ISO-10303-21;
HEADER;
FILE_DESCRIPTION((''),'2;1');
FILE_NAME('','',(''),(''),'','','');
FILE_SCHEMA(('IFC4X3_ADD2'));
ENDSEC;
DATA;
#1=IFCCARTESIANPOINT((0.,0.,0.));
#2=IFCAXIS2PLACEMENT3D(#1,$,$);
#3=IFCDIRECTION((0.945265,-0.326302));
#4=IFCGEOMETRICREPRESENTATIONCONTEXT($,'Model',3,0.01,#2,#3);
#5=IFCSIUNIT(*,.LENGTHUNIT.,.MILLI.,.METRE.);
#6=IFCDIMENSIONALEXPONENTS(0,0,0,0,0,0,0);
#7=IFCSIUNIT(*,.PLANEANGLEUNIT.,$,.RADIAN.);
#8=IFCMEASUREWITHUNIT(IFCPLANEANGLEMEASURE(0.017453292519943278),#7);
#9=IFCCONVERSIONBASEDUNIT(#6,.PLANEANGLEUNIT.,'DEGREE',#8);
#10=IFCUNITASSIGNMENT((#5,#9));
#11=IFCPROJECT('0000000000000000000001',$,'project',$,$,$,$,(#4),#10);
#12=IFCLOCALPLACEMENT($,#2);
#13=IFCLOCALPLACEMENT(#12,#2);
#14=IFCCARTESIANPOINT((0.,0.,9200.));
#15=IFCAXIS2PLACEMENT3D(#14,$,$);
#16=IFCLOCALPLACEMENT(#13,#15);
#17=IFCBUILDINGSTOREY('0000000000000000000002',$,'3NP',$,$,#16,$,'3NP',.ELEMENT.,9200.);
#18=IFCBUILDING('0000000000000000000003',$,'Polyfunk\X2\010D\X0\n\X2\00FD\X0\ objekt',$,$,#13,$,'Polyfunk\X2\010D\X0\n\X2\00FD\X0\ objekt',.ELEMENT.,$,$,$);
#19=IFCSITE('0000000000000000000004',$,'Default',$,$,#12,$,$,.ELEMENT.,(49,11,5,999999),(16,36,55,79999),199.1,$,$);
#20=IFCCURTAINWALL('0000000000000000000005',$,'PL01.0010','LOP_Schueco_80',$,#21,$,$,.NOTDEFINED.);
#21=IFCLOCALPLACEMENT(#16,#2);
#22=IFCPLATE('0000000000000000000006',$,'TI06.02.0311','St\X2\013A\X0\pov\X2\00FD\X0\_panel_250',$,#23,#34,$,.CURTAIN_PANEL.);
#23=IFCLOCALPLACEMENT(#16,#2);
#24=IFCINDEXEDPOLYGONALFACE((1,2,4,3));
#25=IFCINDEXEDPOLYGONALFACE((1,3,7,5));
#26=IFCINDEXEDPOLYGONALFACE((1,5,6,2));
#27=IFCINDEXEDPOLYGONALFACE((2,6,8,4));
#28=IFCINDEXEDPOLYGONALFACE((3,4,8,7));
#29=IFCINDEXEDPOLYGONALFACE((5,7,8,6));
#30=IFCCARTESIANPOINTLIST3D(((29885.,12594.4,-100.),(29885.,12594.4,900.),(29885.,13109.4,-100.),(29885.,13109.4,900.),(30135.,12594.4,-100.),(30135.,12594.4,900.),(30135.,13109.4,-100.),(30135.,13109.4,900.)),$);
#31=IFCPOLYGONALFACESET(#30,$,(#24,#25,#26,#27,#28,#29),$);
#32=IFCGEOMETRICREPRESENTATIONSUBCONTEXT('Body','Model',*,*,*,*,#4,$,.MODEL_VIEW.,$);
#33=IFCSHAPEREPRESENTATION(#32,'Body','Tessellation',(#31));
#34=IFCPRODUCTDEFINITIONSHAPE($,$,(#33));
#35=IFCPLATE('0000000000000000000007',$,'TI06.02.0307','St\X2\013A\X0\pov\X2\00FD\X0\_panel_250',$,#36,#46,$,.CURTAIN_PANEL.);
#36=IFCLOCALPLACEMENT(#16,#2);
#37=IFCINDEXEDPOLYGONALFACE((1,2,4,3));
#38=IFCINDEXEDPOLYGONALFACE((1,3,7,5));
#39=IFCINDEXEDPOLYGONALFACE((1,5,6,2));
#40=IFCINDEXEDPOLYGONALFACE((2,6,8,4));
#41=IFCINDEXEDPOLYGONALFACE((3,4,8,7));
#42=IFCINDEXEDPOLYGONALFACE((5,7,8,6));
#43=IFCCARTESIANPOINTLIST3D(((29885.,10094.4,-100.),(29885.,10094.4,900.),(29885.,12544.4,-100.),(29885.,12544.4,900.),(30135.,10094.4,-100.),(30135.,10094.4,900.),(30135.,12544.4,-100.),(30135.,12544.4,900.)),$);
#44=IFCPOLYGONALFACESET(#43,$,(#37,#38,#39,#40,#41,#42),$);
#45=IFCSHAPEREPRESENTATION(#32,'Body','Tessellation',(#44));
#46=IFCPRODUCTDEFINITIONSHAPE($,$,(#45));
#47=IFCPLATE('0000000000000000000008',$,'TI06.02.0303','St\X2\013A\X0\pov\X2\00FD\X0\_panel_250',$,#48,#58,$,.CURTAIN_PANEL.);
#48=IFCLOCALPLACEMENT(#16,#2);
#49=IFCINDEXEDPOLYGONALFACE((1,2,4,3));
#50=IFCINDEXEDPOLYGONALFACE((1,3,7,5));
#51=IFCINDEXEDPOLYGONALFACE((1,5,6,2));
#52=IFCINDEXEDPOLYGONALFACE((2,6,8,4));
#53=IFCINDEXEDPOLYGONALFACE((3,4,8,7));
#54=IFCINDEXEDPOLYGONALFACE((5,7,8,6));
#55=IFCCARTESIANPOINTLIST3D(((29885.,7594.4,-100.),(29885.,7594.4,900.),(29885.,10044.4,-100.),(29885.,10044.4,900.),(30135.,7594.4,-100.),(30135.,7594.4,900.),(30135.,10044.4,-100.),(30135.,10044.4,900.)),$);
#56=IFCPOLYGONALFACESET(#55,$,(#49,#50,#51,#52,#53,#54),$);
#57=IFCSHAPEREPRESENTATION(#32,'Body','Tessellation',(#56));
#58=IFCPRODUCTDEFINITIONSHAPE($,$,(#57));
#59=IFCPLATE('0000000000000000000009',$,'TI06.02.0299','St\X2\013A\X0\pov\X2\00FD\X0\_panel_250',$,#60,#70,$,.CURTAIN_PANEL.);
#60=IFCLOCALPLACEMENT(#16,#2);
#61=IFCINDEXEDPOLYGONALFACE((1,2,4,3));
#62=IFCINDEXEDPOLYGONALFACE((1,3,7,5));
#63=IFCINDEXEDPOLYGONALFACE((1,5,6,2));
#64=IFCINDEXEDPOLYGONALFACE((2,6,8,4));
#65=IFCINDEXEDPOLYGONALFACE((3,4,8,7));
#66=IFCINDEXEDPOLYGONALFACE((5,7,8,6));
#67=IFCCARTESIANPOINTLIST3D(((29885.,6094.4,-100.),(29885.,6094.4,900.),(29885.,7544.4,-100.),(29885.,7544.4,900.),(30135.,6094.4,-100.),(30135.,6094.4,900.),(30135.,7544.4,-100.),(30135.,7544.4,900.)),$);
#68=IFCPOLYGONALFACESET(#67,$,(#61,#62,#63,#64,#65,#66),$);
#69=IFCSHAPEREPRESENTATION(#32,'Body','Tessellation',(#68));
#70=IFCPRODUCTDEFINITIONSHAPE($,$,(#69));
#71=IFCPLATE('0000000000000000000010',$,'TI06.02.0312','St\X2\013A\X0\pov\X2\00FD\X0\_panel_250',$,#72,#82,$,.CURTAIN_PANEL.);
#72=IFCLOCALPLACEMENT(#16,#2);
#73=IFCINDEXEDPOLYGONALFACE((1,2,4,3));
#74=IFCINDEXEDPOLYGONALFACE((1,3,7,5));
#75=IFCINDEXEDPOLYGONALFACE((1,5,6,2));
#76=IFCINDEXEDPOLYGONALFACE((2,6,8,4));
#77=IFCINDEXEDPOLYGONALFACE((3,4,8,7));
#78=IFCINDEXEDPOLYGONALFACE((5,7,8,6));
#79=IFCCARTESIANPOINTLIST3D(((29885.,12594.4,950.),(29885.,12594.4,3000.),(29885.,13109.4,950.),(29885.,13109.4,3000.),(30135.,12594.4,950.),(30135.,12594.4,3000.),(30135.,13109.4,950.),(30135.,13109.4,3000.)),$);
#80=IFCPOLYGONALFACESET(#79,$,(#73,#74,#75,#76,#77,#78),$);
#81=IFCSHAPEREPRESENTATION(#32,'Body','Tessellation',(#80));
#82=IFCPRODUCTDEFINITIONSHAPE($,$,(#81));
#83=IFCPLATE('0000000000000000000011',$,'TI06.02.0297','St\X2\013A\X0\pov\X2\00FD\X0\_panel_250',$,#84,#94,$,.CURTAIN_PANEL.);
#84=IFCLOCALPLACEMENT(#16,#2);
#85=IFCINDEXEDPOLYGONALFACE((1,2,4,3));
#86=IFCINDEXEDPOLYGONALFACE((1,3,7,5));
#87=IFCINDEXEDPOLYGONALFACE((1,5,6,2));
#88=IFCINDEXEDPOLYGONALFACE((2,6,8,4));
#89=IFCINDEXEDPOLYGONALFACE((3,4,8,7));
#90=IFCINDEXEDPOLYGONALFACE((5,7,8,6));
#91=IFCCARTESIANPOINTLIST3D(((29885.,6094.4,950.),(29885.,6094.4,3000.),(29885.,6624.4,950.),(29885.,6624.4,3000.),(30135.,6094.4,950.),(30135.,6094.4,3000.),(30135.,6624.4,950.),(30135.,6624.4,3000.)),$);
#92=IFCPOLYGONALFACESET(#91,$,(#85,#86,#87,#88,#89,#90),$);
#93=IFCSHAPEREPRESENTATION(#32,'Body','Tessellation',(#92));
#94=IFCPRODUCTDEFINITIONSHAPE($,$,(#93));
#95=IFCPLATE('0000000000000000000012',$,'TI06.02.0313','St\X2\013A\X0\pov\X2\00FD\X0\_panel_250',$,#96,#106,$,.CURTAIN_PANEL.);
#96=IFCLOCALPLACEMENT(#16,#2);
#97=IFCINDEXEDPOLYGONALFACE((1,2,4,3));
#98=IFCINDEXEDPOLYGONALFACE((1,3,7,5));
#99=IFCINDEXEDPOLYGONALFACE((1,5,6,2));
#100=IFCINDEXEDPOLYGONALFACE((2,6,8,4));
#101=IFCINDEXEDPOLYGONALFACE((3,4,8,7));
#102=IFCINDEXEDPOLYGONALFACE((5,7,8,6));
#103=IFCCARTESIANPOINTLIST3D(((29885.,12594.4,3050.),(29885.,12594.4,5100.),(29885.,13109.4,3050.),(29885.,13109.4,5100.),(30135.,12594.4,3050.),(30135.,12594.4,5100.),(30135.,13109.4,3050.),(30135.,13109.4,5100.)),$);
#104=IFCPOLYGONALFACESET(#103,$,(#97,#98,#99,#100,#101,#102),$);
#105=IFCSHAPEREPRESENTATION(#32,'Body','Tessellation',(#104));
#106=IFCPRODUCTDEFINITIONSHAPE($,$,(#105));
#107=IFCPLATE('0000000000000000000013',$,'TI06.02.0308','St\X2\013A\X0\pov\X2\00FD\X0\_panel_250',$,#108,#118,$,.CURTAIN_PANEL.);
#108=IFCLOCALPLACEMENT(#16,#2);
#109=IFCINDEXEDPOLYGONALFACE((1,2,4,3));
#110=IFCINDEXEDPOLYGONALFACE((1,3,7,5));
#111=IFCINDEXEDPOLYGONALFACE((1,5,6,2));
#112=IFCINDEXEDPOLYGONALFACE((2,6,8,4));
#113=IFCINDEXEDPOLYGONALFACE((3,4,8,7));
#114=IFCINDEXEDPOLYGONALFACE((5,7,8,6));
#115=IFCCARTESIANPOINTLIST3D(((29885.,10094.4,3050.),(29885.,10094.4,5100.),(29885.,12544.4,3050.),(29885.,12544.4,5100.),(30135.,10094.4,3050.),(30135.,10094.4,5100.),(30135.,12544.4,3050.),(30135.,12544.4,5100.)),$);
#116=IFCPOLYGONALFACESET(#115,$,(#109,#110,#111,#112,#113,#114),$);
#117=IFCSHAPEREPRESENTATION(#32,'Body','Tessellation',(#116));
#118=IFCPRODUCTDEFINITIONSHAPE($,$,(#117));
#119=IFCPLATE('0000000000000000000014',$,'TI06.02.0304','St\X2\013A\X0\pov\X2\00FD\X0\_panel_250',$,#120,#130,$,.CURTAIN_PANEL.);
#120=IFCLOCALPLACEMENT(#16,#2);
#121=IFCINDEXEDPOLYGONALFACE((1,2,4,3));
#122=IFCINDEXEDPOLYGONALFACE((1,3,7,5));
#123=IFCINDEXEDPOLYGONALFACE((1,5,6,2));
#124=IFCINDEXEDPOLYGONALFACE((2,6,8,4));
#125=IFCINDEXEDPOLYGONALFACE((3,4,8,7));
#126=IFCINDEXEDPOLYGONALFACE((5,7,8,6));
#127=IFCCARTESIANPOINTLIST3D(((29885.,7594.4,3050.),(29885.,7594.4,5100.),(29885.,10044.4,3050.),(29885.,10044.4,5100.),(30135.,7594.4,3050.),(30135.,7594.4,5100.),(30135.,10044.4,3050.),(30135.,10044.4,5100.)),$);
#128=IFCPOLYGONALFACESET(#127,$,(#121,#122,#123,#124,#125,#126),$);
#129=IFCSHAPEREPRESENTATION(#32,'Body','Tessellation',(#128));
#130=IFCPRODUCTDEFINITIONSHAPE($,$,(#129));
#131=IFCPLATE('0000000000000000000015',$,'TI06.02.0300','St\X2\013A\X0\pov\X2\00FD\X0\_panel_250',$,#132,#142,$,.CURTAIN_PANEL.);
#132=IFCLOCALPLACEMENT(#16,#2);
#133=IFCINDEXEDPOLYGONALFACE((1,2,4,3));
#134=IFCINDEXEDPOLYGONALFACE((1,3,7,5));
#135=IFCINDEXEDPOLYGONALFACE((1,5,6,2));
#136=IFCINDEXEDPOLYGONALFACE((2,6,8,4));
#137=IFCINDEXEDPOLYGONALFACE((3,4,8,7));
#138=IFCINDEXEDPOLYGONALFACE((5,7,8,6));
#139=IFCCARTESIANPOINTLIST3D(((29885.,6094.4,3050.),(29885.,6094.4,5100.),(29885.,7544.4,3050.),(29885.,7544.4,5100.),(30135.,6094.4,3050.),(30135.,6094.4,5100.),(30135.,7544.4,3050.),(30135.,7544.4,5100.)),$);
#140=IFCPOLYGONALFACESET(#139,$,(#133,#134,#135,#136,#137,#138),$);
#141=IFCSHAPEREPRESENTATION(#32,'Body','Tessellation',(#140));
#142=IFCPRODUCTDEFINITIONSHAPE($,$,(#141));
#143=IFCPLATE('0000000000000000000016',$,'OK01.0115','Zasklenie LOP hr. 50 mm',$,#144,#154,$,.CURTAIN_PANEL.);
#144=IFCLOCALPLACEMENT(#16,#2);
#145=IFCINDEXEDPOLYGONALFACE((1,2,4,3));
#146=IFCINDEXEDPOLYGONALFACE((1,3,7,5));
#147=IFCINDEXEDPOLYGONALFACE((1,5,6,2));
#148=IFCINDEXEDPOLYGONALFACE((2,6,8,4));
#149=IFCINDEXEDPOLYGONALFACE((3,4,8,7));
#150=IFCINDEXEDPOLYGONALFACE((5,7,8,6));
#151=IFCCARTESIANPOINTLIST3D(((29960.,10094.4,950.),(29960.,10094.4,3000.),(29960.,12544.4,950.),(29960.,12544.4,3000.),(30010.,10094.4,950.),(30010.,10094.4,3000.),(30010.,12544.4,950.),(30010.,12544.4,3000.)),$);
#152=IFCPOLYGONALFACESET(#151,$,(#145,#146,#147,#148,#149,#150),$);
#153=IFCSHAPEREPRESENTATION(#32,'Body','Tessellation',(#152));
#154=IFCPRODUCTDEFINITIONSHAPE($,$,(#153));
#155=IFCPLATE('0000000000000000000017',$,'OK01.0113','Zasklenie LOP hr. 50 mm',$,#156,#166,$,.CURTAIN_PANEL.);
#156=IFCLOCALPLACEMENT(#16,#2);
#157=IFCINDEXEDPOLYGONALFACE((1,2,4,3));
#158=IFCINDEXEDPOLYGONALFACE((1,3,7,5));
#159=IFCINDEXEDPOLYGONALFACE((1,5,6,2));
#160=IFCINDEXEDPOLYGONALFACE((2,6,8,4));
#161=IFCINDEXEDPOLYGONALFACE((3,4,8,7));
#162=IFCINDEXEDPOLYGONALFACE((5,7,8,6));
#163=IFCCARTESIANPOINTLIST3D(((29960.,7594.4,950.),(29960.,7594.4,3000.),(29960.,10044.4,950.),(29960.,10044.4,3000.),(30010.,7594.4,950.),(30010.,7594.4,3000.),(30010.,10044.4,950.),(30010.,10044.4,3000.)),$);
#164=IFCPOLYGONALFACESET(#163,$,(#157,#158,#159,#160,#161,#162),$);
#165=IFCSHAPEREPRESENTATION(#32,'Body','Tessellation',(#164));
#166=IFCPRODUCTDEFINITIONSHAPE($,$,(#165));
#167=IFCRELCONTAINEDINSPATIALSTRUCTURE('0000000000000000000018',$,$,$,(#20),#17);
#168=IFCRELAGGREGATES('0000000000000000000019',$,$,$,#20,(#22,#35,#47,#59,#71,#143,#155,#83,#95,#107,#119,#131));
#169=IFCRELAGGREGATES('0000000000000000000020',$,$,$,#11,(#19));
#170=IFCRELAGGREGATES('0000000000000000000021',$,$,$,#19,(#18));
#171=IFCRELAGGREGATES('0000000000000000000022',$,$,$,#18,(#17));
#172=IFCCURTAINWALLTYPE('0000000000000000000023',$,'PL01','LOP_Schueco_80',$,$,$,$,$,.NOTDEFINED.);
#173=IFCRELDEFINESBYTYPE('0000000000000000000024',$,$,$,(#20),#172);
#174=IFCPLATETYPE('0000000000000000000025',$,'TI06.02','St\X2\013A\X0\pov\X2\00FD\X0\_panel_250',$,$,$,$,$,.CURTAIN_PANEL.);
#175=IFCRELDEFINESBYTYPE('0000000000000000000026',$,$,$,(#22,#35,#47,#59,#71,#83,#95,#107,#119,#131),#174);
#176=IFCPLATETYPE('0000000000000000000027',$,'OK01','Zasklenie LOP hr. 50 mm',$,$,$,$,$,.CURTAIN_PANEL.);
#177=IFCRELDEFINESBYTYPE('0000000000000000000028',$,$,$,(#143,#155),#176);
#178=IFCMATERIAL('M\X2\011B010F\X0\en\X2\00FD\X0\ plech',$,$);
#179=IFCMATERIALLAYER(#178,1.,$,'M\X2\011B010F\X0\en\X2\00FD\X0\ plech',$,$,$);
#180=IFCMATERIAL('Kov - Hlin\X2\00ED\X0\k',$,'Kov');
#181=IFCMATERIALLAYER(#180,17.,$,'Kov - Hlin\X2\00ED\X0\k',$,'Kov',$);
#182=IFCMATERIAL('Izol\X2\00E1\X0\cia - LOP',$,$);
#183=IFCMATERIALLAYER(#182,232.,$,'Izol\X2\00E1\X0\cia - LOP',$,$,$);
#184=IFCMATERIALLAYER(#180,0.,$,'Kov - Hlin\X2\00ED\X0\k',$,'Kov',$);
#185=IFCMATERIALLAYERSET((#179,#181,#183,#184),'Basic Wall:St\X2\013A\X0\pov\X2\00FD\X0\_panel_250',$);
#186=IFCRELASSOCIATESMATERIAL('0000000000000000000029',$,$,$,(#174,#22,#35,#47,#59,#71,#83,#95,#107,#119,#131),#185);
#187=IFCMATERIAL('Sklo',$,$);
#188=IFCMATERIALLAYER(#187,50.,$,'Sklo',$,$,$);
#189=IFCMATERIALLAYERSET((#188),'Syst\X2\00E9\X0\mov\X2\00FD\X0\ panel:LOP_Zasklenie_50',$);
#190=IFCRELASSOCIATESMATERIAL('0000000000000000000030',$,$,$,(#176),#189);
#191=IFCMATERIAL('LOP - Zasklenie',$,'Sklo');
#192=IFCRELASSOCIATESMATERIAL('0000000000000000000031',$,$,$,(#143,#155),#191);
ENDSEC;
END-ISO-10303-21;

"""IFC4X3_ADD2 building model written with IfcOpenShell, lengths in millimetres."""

from ifc_helpers import new_model, entity, si_unit, converted_unit, direction, frame, frame_2d, origin, origin_2d_with_axis, place, context, subcontext, project, spatial, rectangle, extrude, source, transform, mapped, material, layer, layer_set, layer_usage, type_object, element, aggregate, save


model = new_model("IFC4X3_ADD2")

# Units and contexts
model_context = context("Model", 3, precision=0.01, world=origin(), true_north=direction((0.945265, -0.326302)))
body_context = subcontext(model_context, "Body", "Model", "MODEL_VIEW")
ifc_project = project(units=[si_unit("LENGTHUNIT", "METRE", prefix="MILLI"), converted_unit("PLANEANGLEUNIT", "DEGREE", entity("IfcPlaneAngleMeasure", 0.017453292519943278), si_unit("PLANEANGLEUNIT", "RADIAN"), dimensions=[0, 0, 0, 0, 0, 0, 0])], contexts=[model_context])

# Site, building, storey
site_placement = place(None, origin())
site = spatial("IfcSite", under=ifc_project, at=site_placement, Name="Default", CompositionType="ELEMENT", RefLatitude=(49, 11, 5, 999999), RefLongitude=(16, 36, 55, 79999), RefElevation=199.1)
building_placement = place(site_placement, origin())
building = spatial("IfcBuilding", under=site, at=building_placement, Name="Polyfunkčný objekt", LongName="Polyfunkčný objekt", CompositionType="ELEMENT")
storey_placement = place(building_placement, frame((0.0, 0.0, 9200.0)))
storey = spatial("IfcBuildingStorey", under=building, at=storey_placement, Name="3NP", LongName="3NP", CompositionType="ELEMENT", Elevation=9200.0)

# Shared definitions
curtain_wall_type = type_object("IfcCurtainWallType", Name="PL01", Description="LOP_Schueco_80", PredefinedType="NOTDEFINED")

# Curtain wall, plates
curtain_wall_1_placement = place(storey_placement, frame((0.0, 0.0, -9200.0)))
curtain_wall_1 = element("IfcCurtainWall", 1, at=curtain_wall_1_placement, inside=storey, type_object=curtain_wall_type, Name="PL01.0010", Description="LOP_Schueco_80", PredefinedType="NOTDEFINED")
ifc_material_1 = material(Name="Měďený plech")
ifc_layer_1 = layer(ifc_material_1, 1.0, Name="Měďený plech")
ifc_material_2 = material(Name="Kov - Hliník", Category="Kov")
ifc_layer_2 = layer(ifc_material_2, 17.0, Name="Kov - Hliník", Category="Kov")
ifc_material_3 = material(Name="Izolácia - LOP")
ifc_layer_3 = layer(ifc_material_3, 232.0, Name="Izolácia - LOP")
ifc_layer_4 = layer(ifc_material_2, 0.0, Name="Kov - Hliník", Category="Kov")
ifc_layer_set_1 = layer_set([ifc_layer_1, ifc_layer_2, ifc_layer_3, ifc_layer_4], Name="Basic Wall:Stĺpový_panel_250")
ifc_layer_usage_1 = layer_usage(ifc_layer_set_1, "AXIS2", "POSITIVE", -125.0)
plate_type_1 = type_object("IfcPlateType", Name="TI06.02", Description="Stĺpový_panel_250", PredefinedType="CURTAIN_PANEL", material=ifc_layer_set_1)
plate_1_placement = place(storey_placement, frame((30010.0, 13109.4, -100.0), z_axis=(0.0, 0.0, 1.0), x_axis=(0.0, -1.0, 0.0)))
plate_1 = element("IfcPlate", 2, at=plate_1_placement, type_object=plate_type_1, material=ifc_layer_usage_1, Name="TI06.02.0311", Description="Stĺpový_panel_250", PredefinedType="CURTAIN_PANEL", context=body_context, shape_type="SweptSolid", body=[
    extrude(rectangle(XDim=250.0, YDim=515.0, at=frame_2d((0.0, 0.0), x_axis=(1.0, 0.0))), frame((257.5, 0.0, 0.0), z_axis=(0.0, 0.0, 1.0), x_axis=(0.0, 1.0, 0.0)), (0.0, 0.0, 1.0), 1000.0),
])
ifc_layer_usage_2 = layer_usage(ifc_layer_set_1, "AXIS2", "POSITIVE", -125.0)
plate_2_placement = place(storey_placement, frame((30010.0, 12544.4, -100.0), z_axis=(0.0, 0.0, 1.0), x_axis=(0.0, -1.0, 0.0)))
plate_2 = element("IfcPlate", 3, at=plate_2_placement, type_object=plate_type_1, material=ifc_layer_usage_2, Name="TI06.02.0307", Description="Stĺpový_panel_250", PredefinedType="CURTAIN_PANEL", context=body_context, shape_type="SweptSolid", body=[
    extrude(rectangle(XDim=250.0, YDim=2450.0, at=frame_2d((0.0, 0.0), x_axis=(1.0, 0.0))), frame((1225.0, 0.0, 0.0), z_axis=(0.0, 0.0, 1.0), x_axis=(0.0, 1.0, 0.0)), (0.0, 0.0, 1.0), 1000.0),
])
ifc_layer_usage_3 = layer_usage(ifc_layer_set_1, "AXIS2", "POSITIVE", -125.0)
plate_3_placement = place(storey_placement, frame((30010.0, 10044.4, -100.0), z_axis=(0.0, 0.0, 1.0), x_axis=(0.0, -1.0, 0.0)))
plate_3 = element("IfcPlate", 4, at=plate_3_placement, type_object=plate_type_1, material=ifc_layer_usage_3, Name="TI06.02.0303", Description="Stĺpový_panel_250", PredefinedType="CURTAIN_PANEL", context=body_context, shape_type="SweptSolid", body=[
    extrude(rectangle(XDim=250.0, YDim=2450.0, at=origin_2d_with_axis()), frame((1225.0, 0.0, 0.0), z_axis=(0.0, 0.0, 1.0), x_axis=(0.0, 1.0, 0.0)), (0.0, 0.0, 1.0), 1000.0),
])
ifc_layer_usage_4 = layer_usage(ifc_layer_set_1, "AXIS2", "POSITIVE", -125.0)
plate_4_placement = place(storey_placement, frame((30010.0, 7544.4, -100.0), z_axis=(0.0, 0.0, 1.0), x_axis=(0.0, -1.0, 0.0)))
plate_4 = element("IfcPlate", 5, at=plate_4_placement, type_object=plate_type_1, material=ifc_layer_usage_4, Name="TI06.02.0299", Description="Stĺpový_panel_250", PredefinedType="CURTAIN_PANEL", context=body_context, shape_type="SweptSolid", body=[
    extrude(rectangle(XDim=250.0, YDim=1450.0, at=frame_2d((0.0, 0.0), x_axis=(1.0, 0.0))), frame((725.0, 0.0, 0.0), z_axis=(0.0, 0.0, 1.0), x_axis=(0.0, 1.0, 0.0)), (0.0, 0.0, 1.0), 1000.0),
])
ifc_layer_usage_5 = layer_usage(ifc_layer_set_1, "AXIS2", "POSITIVE", -125.0)
plate_5_placement = place(storey_placement, frame((30010.0, 13109.4, 950.0), z_axis=(0.0, 0.0, 1.0), x_axis=(0.0, -1.0, 0.0)))
plate_5 = element("IfcPlate", 6, at=plate_5_placement, type_object=plate_type_1, material=ifc_layer_usage_5, Name="TI06.02.0312", Description="Stĺpový_panel_250", PredefinedType="CURTAIN_PANEL", context=body_context, shape_type="SweptSolid", body=[
    extrude(rectangle(XDim=250.0, YDim=515.0, at=frame_2d((0.0, 0.0), x_axis=(1.0, 0.0))), frame((257.5, 0.0, 0.0), z_axis=(0.0, 0.0, 1.0), x_axis=(0.0, 1.0, 0.0)), (0.0, 0.0, 1.0), 2050.0),
])
ifc_layer_usage_6 = layer_usage(ifc_layer_set_1, "AXIS2", "POSITIVE", -125.0)
plate_6_placement = place(storey_placement, frame((30010.0, 6624.4, 950.0), z_axis=(0.0, 0.0, 1.0), x_axis=(0.0, -1.0, 0.0)))
plate_6 = element("IfcPlate", 7, at=plate_6_placement, type_object=plate_type_1, material=ifc_layer_usage_6, Name="TI06.02.0297", Description="Stĺpový_panel_250", PredefinedType="CURTAIN_PANEL", context=body_context, shape_type="SweptSolid", body=[
    extrude(rectangle(XDim=250.0, YDim=530.0, at=frame_2d((0.0, 0.0), x_axis=(1.0, 0.0))), frame((265.0, 0.0, 0.0), z_axis=(0.0, 0.0, 1.0), x_axis=(0.0, 1.0, 0.0)), (0.0, 0.0, 1.0), 2050.0),
])
ifc_layer_usage_7 = layer_usage(ifc_layer_set_1, "AXIS2", "POSITIVE", -125.0)
plate_7_placement = place(storey_placement, frame((30010.0, 13109.4, 3050.0), z_axis=(0.0, 0.0, 1.0), x_axis=(0.0, -1.0, 0.0)))
plate_7 = element("IfcPlate", 8, at=plate_7_placement, type_object=plate_type_1, material=ifc_layer_usage_7, Name="TI06.02.0313", Description="Stĺpový_panel_250", PredefinedType="CURTAIN_PANEL", context=body_context, shape_type="SweptSolid", body=[
    extrude(rectangle(XDim=250.0, YDim=515.0, at=frame_2d((0.0, 0.0), x_axis=(1.0, 0.0))), frame((257.5, 0.0, 0.0), z_axis=(0.0, 0.0, 1.0), x_axis=(0.0, 1.0, 0.0)), (0.0, 0.0, 1.0), 2050.0),
])
ifc_layer_usage_8 = layer_usage(ifc_layer_set_1, "AXIS2", "POSITIVE", -125.0)
plate_8_placement = place(storey_placement, frame((30010.0, 12544.4, 3050.0), z_axis=(0.0, 0.0, 1.0), x_axis=(0.0, -1.0, 0.0)))
plate_8 = element("IfcPlate", 9, at=plate_8_placement, type_object=plate_type_1, material=ifc_layer_usage_8, Name="TI06.02.0308", Description="Stĺpový_panel_250", PredefinedType="CURTAIN_PANEL", context=body_context, shape_type="SweptSolid", body=[
    extrude(rectangle(XDim=250.0, YDim=2450.0, at=frame_2d((0.0, 0.0), x_axis=(1.0, 0.0))), frame((1225.0, 0.0, 0.0), z_axis=(0.0, 0.0, 1.0), x_axis=(0.0, 1.0, 0.0)), (0.0, 0.0, 1.0), 2050.0),
])
ifc_layer_usage_9 = layer_usage(ifc_layer_set_1, "AXIS2", "POSITIVE", -125.0)
plate_9_placement = place(storey_placement, frame((30010.0, 10044.4, 3050.0), z_axis=(0.0, 0.0, 1.0), x_axis=(0.0, -1.0, 0.0)))
plate_9 = element("IfcPlate", 10, at=plate_9_placement, type_object=plate_type_1, material=ifc_layer_usage_9, Name="TI06.02.0304", Description="Stĺpový_panel_250", PredefinedType="CURTAIN_PANEL", context=body_context, shape_type="SweptSolid", body=[
    extrude(rectangle(XDim=250.0, YDim=2450.0, at=frame_2d((0.0, 0.0), x_axis=(1.0, 0.0))), frame((1225.0, 0.0, 0.0), z_axis=(0.0, 0.0, 1.0), x_axis=(0.0, 1.0, 0.0)), (0.0, 0.0, 1.0), 2050.0),
])
ifc_layer_usage_10 = layer_usage(ifc_layer_set_1, "AXIS2", "POSITIVE", -125.0)
plate_10_placement = place(storey_placement, frame((30010.0, 7544.4, 3050.0), z_axis=(0.0, 0.0, 1.0), x_axis=(0.0, -1.0, 0.0)))
plate_10 = element("IfcPlate", 11, at=plate_10_placement, type_object=plate_type_1, material=ifc_layer_usage_10, Name="TI06.02.0300", Description="Stĺpový_panel_250", PredefinedType="CURTAIN_PANEL", context=body_context, shape_type="SweptSolid", body=[
    extrude(rectangle(XDim=250.0, YDim=1450.0, at=frame_2d((0.0, 0.0), x_axis=(1.0, 0.0))), frame((725.0, 0.0, 0.0), z_axis=(0.0, 0.0, 1.0), x_axis=(0.0, 1.0, 0.0)), (0.0, 0.0, 1.0), 2050.0),
])
ifc_material_4 = material(Name="LOP - Zasklenie", Category="Sklo")
ifc_material_5 = material(Name="Sklo")
ifc_layer_5 = layer(ifc_material_5, 50.0, Name="Sklo")
ifc_layer_set_2 = layer_set([ifc_layer_5], Name="Systémový panel:LOP_Zasklenie_50")
plate_type_2 = type_object("IfcPlateType", Name="OK01", Description="Zasklenie LOP hr. 50 mm", PredefinedType="CURTAIN_PANEL", material=ifc_layer_set_2)
shared_shape_1 = source(origin(), body_context, "Body", "SweptSolid", [
    extrude(rectangle(XDim=50.0, YDim=2450.0, at=origin_2d_with_axis()), frame((0.0, -25.0, 0.0), z_axis=(0.0, 0.0, 1.0), x_axis=(0.0, 1.0, 0.0)), (0.0, 0.0, 1.0), 2050.0),
])
plate_11_placement = place(curtain_wall_1_placement, frame((30010.0, 11319.4, 10150.0), z_axis=(0.0, 0.0, 1.0), x_axis=(0.0, -1.0, 0.0)))
plate_11 = element("IfcPlate", 12, at=plate_11_placement, type_object=plate_type_2, material=ifc_material_4, Name="OK01.0115", Description="Zasklenie LOP hr. 50 mm", PredefinedType="CURTAIN_PANEL", context=body_context, shape_type="MappedRepresentation", body=[
    mapped(shared_shape_1, transform((0.0, 0.0, 0.0), scale=1.0)),
])
plate_12_placement = place(curtain_wall_1_placement, frame((30010.0, 8819.4, 10150.0), z_axis=(0.0, 0.0, 1.0), x_axis=(0.0, -1.0, 0.0)))
plate_12 = element("IfcPlate", 13, at=plate_12_placement, type_object=plate_type_2, material=ifc_material_4, Name="OK01.0113", Description="Zasklenie LOP hr. 50 mm", PredefinedType="CURTAIN_PANEL", context=body_context, shape_type="MappedRepresentation", body=[
    mapped(shared_shape_1, transform((0.0, 0.0, 0.0), scale=1.0)),
])
aggregate(curtain_wall_1, [plate_1, plate_2, plate_3, plate_4, plate_5, plate_11, plate_12, plate_6, plate_7, plate_8, plate_9, plate_10])

save(model, "model.ifc")
